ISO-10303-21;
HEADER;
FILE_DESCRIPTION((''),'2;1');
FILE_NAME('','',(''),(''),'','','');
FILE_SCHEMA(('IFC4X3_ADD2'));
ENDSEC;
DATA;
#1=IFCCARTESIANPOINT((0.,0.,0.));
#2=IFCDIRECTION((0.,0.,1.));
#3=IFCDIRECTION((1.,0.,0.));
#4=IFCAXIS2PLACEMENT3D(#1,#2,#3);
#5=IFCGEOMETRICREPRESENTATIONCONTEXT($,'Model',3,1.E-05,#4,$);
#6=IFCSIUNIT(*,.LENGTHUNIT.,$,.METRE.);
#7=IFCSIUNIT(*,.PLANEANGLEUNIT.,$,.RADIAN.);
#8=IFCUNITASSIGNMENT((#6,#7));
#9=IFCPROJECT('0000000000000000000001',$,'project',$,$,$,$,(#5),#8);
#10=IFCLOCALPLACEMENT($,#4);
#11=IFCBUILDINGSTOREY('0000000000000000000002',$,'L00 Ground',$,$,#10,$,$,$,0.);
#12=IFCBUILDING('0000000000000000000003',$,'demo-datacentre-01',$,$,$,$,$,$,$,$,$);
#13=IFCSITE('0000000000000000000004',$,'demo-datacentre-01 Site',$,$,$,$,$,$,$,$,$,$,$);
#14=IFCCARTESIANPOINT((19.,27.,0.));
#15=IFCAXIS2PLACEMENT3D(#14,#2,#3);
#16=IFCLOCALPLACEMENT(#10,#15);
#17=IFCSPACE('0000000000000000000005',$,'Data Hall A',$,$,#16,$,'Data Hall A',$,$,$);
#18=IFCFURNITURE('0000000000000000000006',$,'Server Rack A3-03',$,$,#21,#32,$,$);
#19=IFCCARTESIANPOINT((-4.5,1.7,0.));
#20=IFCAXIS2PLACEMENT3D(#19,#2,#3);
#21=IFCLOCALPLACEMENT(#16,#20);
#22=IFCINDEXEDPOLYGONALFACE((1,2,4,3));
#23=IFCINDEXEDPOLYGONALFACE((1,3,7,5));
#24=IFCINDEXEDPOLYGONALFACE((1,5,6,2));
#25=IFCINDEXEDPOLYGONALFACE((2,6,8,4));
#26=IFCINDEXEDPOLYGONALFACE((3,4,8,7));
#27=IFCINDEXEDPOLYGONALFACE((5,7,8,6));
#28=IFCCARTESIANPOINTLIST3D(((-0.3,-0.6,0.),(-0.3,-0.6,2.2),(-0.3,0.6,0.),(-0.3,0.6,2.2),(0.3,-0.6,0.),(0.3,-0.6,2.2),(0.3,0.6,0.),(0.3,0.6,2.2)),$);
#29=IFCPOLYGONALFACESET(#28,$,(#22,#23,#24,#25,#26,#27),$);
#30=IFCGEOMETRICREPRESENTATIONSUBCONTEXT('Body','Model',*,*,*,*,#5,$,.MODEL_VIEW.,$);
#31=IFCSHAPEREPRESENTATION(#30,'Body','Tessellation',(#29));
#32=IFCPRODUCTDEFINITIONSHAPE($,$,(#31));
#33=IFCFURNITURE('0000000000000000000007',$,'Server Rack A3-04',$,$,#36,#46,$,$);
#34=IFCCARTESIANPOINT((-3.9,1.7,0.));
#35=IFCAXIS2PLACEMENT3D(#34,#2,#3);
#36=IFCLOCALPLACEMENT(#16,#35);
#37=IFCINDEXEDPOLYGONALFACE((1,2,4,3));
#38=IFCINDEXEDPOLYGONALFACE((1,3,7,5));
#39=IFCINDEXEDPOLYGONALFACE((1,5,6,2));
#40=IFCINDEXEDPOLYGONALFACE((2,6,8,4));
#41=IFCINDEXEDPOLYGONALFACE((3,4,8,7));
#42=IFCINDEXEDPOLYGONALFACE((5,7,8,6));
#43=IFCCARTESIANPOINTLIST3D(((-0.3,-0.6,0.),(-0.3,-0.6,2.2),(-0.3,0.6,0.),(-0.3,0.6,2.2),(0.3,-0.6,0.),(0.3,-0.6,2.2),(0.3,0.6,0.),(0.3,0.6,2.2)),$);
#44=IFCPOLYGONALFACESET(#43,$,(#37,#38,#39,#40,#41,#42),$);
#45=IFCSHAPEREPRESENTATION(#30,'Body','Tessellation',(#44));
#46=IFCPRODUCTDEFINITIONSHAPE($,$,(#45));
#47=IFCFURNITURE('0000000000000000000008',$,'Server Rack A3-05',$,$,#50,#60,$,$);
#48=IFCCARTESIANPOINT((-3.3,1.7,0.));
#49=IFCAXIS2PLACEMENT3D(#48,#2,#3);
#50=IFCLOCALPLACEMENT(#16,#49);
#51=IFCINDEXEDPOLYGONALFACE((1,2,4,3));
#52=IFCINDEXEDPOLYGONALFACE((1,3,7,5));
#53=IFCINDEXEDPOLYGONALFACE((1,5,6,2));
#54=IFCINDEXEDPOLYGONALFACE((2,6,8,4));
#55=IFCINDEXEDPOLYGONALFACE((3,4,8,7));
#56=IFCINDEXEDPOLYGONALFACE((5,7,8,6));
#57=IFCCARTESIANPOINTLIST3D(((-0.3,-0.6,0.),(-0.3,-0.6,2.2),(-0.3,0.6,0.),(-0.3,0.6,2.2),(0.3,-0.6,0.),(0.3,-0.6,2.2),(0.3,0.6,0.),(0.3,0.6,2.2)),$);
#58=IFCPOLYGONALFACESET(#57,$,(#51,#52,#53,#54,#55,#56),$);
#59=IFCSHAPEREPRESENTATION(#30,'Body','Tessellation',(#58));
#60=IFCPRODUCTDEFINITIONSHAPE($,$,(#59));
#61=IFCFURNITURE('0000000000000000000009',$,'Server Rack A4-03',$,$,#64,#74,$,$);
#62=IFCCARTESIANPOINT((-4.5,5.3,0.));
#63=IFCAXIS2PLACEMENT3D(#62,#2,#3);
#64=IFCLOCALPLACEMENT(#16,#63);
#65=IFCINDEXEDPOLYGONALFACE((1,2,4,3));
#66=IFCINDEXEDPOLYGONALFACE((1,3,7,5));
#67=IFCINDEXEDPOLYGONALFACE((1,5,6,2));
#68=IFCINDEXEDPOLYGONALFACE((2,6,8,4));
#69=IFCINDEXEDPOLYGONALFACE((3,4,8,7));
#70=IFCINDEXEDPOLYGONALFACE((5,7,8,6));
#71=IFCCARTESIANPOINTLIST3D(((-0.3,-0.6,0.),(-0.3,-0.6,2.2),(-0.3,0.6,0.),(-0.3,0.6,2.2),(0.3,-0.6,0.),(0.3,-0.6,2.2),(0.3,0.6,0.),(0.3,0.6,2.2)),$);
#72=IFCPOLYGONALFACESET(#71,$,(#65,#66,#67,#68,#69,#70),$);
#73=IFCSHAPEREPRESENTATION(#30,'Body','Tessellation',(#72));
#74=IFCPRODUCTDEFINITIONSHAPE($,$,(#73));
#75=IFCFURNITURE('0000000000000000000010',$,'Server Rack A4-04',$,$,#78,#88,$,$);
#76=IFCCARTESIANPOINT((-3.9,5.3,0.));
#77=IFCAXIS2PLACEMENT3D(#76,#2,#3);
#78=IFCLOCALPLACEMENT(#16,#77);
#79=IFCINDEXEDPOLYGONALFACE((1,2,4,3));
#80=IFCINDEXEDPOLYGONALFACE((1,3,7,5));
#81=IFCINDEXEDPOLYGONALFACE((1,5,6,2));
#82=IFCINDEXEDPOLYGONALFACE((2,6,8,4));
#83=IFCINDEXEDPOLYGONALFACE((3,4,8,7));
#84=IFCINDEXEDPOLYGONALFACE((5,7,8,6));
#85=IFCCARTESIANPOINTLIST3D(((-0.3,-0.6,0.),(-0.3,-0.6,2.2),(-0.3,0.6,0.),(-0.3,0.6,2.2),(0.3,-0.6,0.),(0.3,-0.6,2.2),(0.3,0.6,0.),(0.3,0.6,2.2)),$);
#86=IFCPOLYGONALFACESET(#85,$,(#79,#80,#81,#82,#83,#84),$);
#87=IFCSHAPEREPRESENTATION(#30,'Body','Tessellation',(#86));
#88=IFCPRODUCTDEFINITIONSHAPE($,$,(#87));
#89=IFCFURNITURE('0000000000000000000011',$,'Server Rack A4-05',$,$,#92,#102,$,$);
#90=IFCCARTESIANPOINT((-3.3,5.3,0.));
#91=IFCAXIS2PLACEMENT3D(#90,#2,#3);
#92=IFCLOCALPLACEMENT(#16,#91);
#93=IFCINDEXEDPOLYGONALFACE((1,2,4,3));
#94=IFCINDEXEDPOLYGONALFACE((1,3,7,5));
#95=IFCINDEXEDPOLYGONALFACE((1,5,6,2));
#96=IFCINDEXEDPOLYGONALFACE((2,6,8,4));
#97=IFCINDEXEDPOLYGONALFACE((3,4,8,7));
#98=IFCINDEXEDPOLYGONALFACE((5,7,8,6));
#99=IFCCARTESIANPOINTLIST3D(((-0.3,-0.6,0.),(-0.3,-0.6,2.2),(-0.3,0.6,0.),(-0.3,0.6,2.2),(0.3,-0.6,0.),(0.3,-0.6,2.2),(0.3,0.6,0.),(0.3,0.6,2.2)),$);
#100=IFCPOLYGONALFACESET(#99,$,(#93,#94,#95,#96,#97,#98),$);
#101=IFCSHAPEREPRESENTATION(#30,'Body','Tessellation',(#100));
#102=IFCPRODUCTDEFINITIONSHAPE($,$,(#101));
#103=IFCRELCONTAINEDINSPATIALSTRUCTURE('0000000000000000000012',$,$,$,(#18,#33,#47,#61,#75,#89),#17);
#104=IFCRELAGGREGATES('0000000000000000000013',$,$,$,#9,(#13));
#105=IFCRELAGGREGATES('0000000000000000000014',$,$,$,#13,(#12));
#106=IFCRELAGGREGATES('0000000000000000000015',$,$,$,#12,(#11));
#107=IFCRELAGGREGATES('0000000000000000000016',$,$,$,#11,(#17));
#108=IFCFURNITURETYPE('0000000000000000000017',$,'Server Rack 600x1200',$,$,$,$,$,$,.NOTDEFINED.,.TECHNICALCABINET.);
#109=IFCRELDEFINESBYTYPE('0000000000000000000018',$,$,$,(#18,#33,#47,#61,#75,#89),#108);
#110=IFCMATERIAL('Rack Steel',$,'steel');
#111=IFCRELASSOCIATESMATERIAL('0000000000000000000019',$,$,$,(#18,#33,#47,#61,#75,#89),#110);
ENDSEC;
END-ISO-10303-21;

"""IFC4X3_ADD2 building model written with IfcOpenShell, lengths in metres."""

from ifc_helpers import new_model, si_unit, frame, origin_with_axes, place, context, subcontext, project, spatial, rectangle, extrude, material, type_object, element, save


model = new_model("IFC4X3_ADD2")

# Units and contexts
model_context = context("Model", 3, precision=1e-05, world=origin_with_axes())
body_context = subcontext(model_context, "Body", "Model", "MODEL_VIEW")
ifc_project = project(units=[si_unit("LENGTHUNIT", "METRE"), si_unit("PLANEANGLEUNIT", "RADIAN")], contexts=[model_context])

# Site, building, storey
site = spatial("IfcSite", under=ifc_project, Name="demo-datacentre-01 Site")
building = spatial("IfcBuilding", under=site, Name="demo-datacentre-01")
storey_placement = place(None, origin_with_axes())
storey = spatial("IfcBuildingStorey", under=building, at=storey_placement, Name="L00 Ground", Elevation=0.0)

# Shared definitions
space_placement = place(storey_placement, frame((19.0, 27.0, 0.0), z_axis=(0.0, 0.0, 1.0), x_axis=(1.0, 0.0, 0.0)))
space = spatial("IfcSpace", under=storey, at=space_placement, Name="Data Hall A", LongName="Data Hall A")

# Furniture
ifc_material_1 = material(Name="Rack Steel", Category="steel")
furniture_type = type_object("IfcFurnitureType", Name="Server Rack 600x1200", AssemblyPlace="NOTDEFINED", PredefinedType="TECHNICALCABINET")
for number, where, z_axis, x_axis, name in (
    (1, (-4.5, 1.7, 0.0), (0.0, 0.0, 1.0), (1.0, 0.0, 0.0), "Server Rack A3-03"),
    (2, (-3.9, 1.7, 0.0), (0.0, 0.0, 1.0), (1.0, 0.0, 0.0), "Server Rack A3-04"),
    (3, (-3.3, 1.7, 0.0), (0.0, 0.0, 1.0), (1.0, 0.0, 0.0), "Server Rack A3-05"),
    (4, (-4.5, 5.3, 0.0), (0.0, 0.0, 1.0), (1.0, 0.0, 0.0), "Server Rack A4-03"),
    (5, (-3.9, 5.3, 0.0), (0.0, 0.0, 1.0), (1.0, 0.0, 0.0), "Server Rack A4-04"),
    (6, (-3.3, 5.3, 0.0), (0.0, 0.0, 1.0), (1.0, 0.0, 0.0), "Server Rack A4-05"),
):
    element("IfcFurniture", number, at=place(space_placement, frame(where, z_axis=z_axis, x_axis=x_axis)), inside=space, type_object=furniture_type, material=ifc_material_1, Name=name, context=body_context, shape_type="SweptSolid", body=[
        extrude(rectangle(XDim=0.6, YDim=1.2), origin_with_axes(), (0.0, 0.0, 1.0), 2.2),
    ])

save(model, "model.ifc")
